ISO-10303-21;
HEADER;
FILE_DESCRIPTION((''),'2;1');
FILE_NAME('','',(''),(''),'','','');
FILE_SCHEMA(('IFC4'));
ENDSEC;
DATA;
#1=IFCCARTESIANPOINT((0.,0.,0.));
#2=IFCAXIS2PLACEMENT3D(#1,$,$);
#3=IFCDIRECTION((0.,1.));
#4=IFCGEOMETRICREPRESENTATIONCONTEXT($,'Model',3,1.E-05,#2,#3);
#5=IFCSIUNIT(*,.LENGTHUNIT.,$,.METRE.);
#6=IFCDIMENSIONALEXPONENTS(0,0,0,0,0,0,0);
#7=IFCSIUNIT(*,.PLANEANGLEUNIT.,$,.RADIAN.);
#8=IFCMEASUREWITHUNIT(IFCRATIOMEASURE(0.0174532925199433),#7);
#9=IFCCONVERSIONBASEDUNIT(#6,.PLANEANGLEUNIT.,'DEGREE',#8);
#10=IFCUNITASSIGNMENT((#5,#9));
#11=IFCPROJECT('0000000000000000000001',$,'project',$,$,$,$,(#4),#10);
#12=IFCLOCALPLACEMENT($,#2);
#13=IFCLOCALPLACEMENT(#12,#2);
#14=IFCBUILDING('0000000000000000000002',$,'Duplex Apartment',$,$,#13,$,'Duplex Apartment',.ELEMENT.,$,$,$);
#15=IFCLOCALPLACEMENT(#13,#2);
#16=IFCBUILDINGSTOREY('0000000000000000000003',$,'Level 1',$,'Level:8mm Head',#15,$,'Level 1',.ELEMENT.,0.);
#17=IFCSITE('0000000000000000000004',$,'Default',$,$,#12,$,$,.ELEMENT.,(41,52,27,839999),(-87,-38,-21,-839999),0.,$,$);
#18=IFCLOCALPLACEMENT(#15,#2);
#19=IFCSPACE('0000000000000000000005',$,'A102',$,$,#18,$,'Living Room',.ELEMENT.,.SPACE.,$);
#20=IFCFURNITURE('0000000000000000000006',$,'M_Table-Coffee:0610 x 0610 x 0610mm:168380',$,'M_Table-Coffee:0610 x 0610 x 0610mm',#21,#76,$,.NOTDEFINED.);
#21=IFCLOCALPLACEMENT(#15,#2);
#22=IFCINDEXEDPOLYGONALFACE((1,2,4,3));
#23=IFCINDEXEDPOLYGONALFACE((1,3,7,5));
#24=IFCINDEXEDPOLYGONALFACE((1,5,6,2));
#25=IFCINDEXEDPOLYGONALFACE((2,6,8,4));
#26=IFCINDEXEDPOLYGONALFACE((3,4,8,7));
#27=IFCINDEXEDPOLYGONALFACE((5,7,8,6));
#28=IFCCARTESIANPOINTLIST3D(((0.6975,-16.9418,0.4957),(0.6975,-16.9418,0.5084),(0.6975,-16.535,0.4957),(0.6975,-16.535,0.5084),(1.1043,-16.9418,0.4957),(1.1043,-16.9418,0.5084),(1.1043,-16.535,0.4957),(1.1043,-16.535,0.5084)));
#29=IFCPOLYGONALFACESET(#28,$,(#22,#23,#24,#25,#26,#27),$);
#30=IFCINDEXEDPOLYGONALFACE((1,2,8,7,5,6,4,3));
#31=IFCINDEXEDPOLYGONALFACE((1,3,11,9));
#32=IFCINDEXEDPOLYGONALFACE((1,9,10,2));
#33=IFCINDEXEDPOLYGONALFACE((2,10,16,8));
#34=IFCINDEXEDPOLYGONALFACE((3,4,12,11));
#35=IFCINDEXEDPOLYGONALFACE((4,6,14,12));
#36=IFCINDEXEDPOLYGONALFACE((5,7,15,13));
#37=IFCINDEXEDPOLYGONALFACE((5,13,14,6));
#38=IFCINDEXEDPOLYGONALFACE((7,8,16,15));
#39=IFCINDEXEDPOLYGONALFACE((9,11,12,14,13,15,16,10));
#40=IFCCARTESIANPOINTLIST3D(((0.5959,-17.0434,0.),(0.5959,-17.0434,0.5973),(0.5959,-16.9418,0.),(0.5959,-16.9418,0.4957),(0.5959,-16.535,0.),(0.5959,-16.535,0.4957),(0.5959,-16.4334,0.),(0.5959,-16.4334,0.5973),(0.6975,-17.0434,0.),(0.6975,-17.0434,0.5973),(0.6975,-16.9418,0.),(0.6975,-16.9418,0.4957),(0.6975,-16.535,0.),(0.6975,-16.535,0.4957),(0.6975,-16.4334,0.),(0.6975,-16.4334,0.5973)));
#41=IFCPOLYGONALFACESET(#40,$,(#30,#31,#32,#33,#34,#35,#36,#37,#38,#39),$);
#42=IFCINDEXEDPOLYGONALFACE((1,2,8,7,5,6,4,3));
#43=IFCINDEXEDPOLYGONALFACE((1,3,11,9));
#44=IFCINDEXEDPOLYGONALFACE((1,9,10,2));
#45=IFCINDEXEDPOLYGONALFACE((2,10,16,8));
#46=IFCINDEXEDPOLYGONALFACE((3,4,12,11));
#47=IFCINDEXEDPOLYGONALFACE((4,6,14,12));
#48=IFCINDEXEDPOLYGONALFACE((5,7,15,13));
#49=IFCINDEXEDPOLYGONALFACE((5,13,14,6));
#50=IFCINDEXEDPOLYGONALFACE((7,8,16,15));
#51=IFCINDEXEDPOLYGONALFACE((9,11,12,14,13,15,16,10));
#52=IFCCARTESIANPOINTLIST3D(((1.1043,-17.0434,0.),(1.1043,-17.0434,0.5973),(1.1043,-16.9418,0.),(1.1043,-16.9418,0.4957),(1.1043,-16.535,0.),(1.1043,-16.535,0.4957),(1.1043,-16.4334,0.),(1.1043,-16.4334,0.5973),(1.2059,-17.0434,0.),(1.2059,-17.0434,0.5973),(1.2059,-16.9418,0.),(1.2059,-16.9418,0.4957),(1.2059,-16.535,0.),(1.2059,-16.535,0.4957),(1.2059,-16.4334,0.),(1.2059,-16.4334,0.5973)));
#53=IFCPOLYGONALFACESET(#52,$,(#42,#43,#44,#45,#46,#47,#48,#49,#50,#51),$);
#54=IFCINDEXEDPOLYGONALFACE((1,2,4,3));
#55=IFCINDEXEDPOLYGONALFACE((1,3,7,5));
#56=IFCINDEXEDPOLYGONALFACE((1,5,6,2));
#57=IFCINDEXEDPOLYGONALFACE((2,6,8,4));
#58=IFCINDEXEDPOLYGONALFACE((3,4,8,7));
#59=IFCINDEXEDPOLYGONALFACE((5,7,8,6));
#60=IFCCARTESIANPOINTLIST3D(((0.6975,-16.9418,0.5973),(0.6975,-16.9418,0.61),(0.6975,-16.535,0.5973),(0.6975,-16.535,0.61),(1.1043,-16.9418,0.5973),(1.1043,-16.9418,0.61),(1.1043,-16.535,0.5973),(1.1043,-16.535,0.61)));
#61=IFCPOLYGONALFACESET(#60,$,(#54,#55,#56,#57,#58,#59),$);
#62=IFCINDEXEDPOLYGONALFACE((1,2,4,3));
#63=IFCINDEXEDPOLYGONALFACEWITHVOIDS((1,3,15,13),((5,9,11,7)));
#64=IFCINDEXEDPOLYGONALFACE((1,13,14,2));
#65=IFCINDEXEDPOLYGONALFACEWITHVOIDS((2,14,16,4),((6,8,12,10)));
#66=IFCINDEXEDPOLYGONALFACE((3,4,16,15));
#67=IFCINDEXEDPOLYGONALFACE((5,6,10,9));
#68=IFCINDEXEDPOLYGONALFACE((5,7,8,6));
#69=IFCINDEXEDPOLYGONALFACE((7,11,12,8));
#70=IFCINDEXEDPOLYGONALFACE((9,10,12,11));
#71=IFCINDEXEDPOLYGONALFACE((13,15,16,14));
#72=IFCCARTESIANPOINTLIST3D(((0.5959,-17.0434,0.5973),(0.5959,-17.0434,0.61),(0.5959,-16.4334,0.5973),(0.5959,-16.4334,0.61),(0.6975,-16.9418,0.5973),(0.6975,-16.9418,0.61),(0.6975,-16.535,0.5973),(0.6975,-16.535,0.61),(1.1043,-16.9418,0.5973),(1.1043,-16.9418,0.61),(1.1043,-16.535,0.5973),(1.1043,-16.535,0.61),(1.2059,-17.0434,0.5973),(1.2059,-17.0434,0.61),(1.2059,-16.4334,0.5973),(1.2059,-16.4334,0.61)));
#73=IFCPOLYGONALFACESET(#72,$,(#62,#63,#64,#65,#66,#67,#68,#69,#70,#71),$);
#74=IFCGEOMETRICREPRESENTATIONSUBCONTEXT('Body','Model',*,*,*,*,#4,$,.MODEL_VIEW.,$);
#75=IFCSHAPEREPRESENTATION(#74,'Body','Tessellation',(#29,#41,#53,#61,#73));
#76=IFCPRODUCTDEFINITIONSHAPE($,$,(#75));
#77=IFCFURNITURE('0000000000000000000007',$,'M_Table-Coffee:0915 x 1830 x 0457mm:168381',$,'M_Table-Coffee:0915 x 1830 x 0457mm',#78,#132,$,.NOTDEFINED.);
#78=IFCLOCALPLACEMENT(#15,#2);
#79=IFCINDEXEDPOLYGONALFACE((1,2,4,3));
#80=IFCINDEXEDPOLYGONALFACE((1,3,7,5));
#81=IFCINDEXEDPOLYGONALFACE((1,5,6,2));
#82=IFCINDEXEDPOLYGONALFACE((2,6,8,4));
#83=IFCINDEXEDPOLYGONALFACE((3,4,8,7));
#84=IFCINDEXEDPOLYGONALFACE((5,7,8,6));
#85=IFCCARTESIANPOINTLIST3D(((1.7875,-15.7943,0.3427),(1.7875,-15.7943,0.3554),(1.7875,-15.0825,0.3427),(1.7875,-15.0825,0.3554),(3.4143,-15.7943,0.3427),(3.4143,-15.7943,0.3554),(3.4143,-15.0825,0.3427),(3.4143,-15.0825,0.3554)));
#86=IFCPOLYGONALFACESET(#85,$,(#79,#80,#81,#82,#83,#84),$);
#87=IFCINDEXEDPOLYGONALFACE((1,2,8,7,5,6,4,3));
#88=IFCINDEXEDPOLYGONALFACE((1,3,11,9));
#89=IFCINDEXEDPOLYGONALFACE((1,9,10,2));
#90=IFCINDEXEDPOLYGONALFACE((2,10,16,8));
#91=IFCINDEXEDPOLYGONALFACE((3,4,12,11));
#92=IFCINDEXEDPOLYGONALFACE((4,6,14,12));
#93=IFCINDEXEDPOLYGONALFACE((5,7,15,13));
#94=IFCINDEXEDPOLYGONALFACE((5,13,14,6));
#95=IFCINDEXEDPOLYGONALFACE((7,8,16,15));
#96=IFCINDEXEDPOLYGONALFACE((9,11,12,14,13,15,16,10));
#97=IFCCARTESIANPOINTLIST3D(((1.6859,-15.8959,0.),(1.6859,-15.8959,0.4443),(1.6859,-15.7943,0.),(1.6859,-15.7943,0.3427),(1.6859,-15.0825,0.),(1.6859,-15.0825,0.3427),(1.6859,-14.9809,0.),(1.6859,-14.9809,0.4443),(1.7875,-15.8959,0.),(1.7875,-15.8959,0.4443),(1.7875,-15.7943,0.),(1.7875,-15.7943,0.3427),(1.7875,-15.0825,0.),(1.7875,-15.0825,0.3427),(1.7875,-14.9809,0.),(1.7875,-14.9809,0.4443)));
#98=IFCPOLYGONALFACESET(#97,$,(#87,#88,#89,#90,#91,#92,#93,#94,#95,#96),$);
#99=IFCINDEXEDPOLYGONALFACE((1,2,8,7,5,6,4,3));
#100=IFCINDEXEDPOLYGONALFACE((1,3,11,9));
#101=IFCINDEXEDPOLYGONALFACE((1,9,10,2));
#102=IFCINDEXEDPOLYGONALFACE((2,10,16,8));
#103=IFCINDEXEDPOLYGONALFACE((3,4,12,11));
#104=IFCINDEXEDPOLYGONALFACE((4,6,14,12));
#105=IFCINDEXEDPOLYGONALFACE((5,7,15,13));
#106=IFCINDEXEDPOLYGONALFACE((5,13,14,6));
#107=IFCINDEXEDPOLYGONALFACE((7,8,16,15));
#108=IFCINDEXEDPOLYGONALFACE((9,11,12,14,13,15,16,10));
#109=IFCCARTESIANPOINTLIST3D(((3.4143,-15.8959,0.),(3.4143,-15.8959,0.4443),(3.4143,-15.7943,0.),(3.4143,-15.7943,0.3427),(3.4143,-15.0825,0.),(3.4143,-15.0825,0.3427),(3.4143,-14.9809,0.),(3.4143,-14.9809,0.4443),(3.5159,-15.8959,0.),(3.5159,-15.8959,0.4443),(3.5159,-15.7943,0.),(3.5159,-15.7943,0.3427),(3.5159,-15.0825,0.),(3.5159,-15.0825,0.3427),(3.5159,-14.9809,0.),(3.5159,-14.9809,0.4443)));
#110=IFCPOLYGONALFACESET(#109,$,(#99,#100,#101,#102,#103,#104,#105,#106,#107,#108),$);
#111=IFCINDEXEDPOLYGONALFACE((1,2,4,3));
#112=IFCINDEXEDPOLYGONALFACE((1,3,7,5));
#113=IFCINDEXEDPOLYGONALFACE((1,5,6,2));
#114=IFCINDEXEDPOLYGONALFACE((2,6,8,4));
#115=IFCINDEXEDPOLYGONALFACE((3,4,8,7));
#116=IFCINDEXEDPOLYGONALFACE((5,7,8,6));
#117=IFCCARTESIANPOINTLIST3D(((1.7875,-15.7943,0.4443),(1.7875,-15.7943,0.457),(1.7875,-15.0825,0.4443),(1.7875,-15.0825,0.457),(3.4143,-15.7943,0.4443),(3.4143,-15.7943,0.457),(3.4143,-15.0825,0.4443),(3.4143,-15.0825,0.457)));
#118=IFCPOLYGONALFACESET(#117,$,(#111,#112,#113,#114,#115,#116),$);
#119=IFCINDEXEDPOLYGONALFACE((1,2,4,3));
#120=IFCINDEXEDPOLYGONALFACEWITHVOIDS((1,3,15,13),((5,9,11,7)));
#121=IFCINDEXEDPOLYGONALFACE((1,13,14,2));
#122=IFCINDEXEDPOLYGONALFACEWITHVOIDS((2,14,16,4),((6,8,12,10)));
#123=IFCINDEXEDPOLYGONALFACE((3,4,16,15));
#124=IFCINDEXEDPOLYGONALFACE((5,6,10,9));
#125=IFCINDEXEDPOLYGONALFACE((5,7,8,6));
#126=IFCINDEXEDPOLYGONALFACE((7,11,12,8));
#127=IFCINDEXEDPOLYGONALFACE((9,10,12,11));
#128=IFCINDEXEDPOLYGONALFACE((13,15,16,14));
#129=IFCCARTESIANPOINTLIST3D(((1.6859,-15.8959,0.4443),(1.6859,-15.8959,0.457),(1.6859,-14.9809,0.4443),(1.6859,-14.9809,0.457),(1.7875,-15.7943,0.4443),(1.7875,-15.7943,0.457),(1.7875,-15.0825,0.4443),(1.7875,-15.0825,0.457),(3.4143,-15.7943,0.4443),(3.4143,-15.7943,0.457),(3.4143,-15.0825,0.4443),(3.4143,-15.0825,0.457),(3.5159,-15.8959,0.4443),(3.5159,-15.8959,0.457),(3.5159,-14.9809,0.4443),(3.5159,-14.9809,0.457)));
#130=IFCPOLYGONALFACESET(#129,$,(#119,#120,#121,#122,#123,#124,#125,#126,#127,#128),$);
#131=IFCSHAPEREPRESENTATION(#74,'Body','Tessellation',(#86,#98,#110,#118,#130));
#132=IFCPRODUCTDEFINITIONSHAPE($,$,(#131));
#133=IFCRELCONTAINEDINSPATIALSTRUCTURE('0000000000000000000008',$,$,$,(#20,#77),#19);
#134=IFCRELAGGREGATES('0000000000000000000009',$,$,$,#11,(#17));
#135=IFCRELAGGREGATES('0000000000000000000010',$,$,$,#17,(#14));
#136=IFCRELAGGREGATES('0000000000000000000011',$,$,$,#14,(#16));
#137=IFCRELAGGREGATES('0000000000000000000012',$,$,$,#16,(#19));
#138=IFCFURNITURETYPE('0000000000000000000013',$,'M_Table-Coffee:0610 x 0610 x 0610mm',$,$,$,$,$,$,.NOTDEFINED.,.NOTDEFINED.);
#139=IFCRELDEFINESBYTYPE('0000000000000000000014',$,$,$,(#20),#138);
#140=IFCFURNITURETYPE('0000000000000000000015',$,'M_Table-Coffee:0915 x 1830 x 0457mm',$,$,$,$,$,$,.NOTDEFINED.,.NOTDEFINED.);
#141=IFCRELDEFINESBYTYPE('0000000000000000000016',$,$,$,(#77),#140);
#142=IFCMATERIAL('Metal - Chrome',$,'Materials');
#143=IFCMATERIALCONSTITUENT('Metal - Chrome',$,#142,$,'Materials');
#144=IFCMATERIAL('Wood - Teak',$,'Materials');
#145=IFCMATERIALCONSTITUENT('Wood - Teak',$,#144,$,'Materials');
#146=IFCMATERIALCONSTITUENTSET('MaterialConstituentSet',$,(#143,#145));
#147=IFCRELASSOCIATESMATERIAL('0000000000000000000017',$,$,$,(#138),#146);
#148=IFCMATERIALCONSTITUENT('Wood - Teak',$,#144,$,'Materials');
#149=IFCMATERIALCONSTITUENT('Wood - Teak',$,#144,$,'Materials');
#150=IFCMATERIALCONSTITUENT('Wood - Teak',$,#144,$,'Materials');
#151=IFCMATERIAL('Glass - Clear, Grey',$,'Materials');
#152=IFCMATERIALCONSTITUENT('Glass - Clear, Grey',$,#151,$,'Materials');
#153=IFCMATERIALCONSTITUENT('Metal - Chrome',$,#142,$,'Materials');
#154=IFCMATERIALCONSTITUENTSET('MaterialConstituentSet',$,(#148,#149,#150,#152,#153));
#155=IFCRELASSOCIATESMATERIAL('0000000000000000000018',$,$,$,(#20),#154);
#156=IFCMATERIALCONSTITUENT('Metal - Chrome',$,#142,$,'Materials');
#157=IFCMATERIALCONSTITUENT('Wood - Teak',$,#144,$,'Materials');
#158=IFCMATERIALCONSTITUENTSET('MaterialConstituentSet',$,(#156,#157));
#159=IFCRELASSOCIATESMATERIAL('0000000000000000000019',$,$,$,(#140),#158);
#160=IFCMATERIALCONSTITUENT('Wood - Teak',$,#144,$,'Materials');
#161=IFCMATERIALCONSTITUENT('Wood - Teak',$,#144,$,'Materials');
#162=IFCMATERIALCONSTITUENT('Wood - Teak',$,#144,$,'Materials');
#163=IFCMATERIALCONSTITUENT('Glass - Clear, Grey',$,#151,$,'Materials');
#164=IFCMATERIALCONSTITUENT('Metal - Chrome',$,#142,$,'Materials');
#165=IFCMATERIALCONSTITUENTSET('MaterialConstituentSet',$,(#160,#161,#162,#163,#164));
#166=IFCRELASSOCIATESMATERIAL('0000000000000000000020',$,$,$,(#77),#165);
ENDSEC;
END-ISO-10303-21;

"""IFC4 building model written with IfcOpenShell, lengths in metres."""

from ifc_helpers import new_model, entity, si_unit, converted_unit, direction, frame, origin, place, context, subcontext, project, spatial, indexed_curve, outline, extrude, source, transform, mapped, material, constituent, constituent_set, type_object, type_shapes, element, save


model = new_model("IFC4")

# Units and contexts
model_context = context("Model", 3, precision=1e-05, world=origin(), true_north=direction((0.0, 1.0)))
body_context = subcontext(model_context, "Body", "Model", "MODEL_VIEW")
ifc_project = project(units=[si_unit("LENGTHUNIT", "METRE"), converted_unit("PLANEANGLEUNIT", "DEGREE", entity("IfcRatioMeasure", 0.0174532925199433), si_unit("PLANEANGLEUNIT", "RADIAN"), dimensions=[0, 0, 0, 0, 0, 0, 0])], contexts=[model_context])

# Site, building, storey
site_placement = place(None, origin())
site = spatial("IfcSite", under=ifc_project, at=site_placement, Name="Default", CompositionType="ELEMENT", RefLatitude=(41, 52, 27, 839999), RefLongitude=(-87, -38, -21, -839999), RefElevation=0.0)
building_placement = place(site_placement, origin())
building = spatial("IfcBuilding", under=site, at=building_placement, Name="Duplex Apartment", LongName="Duplex Apartment", CompositionType="ELEMENT")
storey_placement = place(building_placement, origin())
storey = spatial("IfcBuildingStorey", under=building, at=storey_placement, Name="Level 1", ObjectType="Level:8mm Head", LongName="Level 1", CompositionType="ELEMENT", Elevation=0.0)

# Shared definitions
space_1_placement = place(storey_placement, origin())
space_1 = spatial("IfcSpace", under=storey, at=space_1_placement, Name="A102", LongName="Living Room", CompositionType="ELEMENT", PredefinedType="SPACE")

# Furniture
ifc_material_1 = material(Name="Wood - Teak", Category="Materials")
ifc_material_2 = material(Name="Glass - Clear, Grey", Category="Materials")
ifc_material_3 = material(Name="Metal - Chrome", Category="Materials")
ifc_constituent_1 = constituent(ifc_material_3, Name="Metal - Chrome", Category="Materials")
ifc_constituent_2 = constituent(ifc_material_1, Name="Wood - Teak", Category="Materials")
ifc_constituent_set_1 = constituent_set(constituents=[ifc_constituent_1, ifc_constituent_2], Name="MaterialConstituentSet")
furniture_type_1 = type_object("IfcFurnitureType", Name="M_Table-Coffee:0610 x 0610 x 0610mm", AssemblyPlace="NOTDEFINED", PredefinedType="NOTDEFINED", material=ifc_constituent_set_1)
shared_shape_1 = source(origin(), body_context, "Body", "SweptSolid", [
    extrude(outline(indexed_curve([(-0.2034, -0.2034), (0.2034, -0.2034), (0.2034, 0.2034), (-0.2034, 0.2034), (-0.2034, -0.2034)], self_intersect=False)), frame((0.0183, 0.0952, 0.4957), z_axis=(0.0, 0.0, 1.0), x_axis=(-1.0, 0.0, 0.0)), (0.0, 0.0, 1.0), 0.0127),
    extrude(outline(indexed_curve([(-0.2732, -0.305), (0.324, -0.305), (0.324, 0.305), (-0.2732, 0.305), (-0.2732, 0.2034), (0.2225, 0.2034), (0.2225, -0.2034), (-0.2732, -0.2034), (-0.2732, -0.305)], self_intersect=False)), frame((0.2217, 0.0952, 0.2732), z_axis=(1.0, 0.0, 0.0), x_axis=(0.0, 0.0, 1.0)), (0.0, 0.0, 1.0), 0.1016),
    extrude(outline(indexed_curve([(-0.305, -0.3241), (0.305, -0.3241), (0.305, 0.2733), (0.2034, 0.2733), (0.2034, -0.2224), (-0.2034, -0.2224), (-0.2034, 0.2733), (-0.305, 0.2733), (-0.305, -0.3241)], self_intersect=False)), frame((-0.2867, 0.0952, 0.2733), z_axis=(1.0, 0.0, 0.0), x_axis=(0.0, -1.0, 0.0)), (0.0, 0.0, 1.0), 0.1016),
    extrude(outline(indexed_curve([(-0.2034, -0.2034), (0.2034, -0.2034), (0.2034, 0.2034), (-0.2034, 0.2034), (-0.2034, -0.2034)], self_intersect=False)), frame((0.0183, 0.0952, 0.5973), z_axis=(0.0, 0.0, 1.0), x_axis=(-1.0, 0.0, 0.0)), (0.0, 0.0, 1.0), 0.0127),
    extrude(outline(indexed_curve([(-0.305, -0.305), (0.305, -0.305), (0.305, 0.305), (-0.305, 0.305), (-0.305, -0.305)], self_intersect=False), holes=[indexed_curve([(-0.2034, -0.2034), (-0.2034, 0.2034), (0.2034, 0.2034), (0.2034, -0.2034), (-0.2034, -0.2034)], self_intersect=False)]), frame((0.0183, 0.0952, 0.5973), z_axis=(0.0, 0.0, 1.0), x_axis=(-1.0, 0.0, 0.0)), (0.0, 0.0, 1.0), 0.0127),
])
type_shapes(furniture_type_1, [shared_shape_1])
ifc_constituent_3 = constituent(ifc_material_1, Name="Wood - Teak", Category="Materials")
ifc_constituent_4 = constituent(ifc_material_1, Name="Wood - Teak", Category="Materials")
ifc_constituent_5 = constituent(ifc_material_1, Name="Wood - Teak", Category="Materials")
ifc_constituent_6 = constituent(ifc_material_2, Name="Glass - Clear, Grey", Category="Materials")
ifc_constituent_7 = constituent(ifc_material_3, Name="Metal - Chrome", Category="Materials")
ifc_constituent_set_2 = constituent_set(constituents=[ifc_constituent_3, ifc_constituent_4, ifc_constituent_5, ifc_constituent_6, ifc_constituent_7], Name="MaterialConstituentSet")
furniture_1_placement = place(space_1_placement, frame((0.9192, -16.6432, 0.0), z_axis=(0.0, 0.0, 1.0), x_axis=(-1.0, 0.0, 0.0)))
element("IfcFurniture", 1, at=furniture_1_placement, inside=space_1, type_object=furniture_type_1, material=ifc_constituent_set_2, Name="M_Table-Coffee:0610 x 0610 x 0610mm:168380", ObjectType="M_Table-Coffee:0610 x 0610 x 0610mm", PredefinedType="NOTDEFINED", context=body_context, shape_type="MappedRepresentation", body=[
    mapped(shared_shape_1, transform((0.0, 0.0, 0.0), scale=1.0)),
])
ifc_constituent_8 = constituent(ifc_material_1, Name="Wood - Teak", Category="Materials")
ifc_constituent_9 = constituent(ifc_material_1, Name="Wood - Teak", Category="Materials")
ifc_constituent_10 = constituent(ifc_material_1, Name="Wood - Teak", Category="Materials")
ifc_constituent_11 = constituent(ifc_material_2, Name="Glass - Clear, Grey", Category="Materials")
ifc_constituent_12 = constituent(ifc_material_3, Name="Metal - Chrome", Category="Materials")
ifc_constituent_set_3 = constituent_set(constituents=[ifc_constituent_8, ifc_constituent_9, ifc_constituent_10, ifc_constituent_11, ifc_constituent_12], Name="MaterialConstituentSet")
ifc_constituent_13 = constituent(ifc_material_3, Name="Metal - Chrome", Category="Materials")
ifc_constituent_14 = constituent(ifc_material_1, Name="Wood - Teak", Category="Materials")
ifc_constituent_set_4 = constituent_set(constituents=[ifc_constituent_13, ifc_constituent_14], Name="MaterialConstituentSet")
furniture_type_2 = type_object("IfcFurnitureType", Name="M_Table-Coffee:0915 x 1830 x 0457mm", AssemblyPlace="NOTDEFINED", PredefinedType="NOTDEFINED", material=ifc_constituent_set_4)
shared_shape_2 = source(origin(), body_context, "Body", "SweptSolid", [
    extrude(outline(indexed_curve([(-0.8134, -0.3559), (0.8134, -0.3559), (0.8134, 0.3559), (-0.8134, 0.3559), (-0.8134, -0.3559)], self_intersect=False)), frame((0.0183, 0.0952, 0.3427), z_axis=(0.0, 0.0, 1.0), x_axis=(-1.0, 0.0, 0.0)), (0.0, 0.0, 1.0), 0.0127),
    extrude(outline(indexed_curve([(-0.1967, -0.4575), (0.2475, -0.4575), (0.2475, 0.4575), (-0.1967, 0.4575), (-0.1967, 0.3559), (0.146, 0.3559), (0.146, -0.3559), (-0.1967, -0.3559), (-0.1967, -0.4575)], self_intersect=False)), frame((0.8317, 0.0952, 0.1967), z_axis=(1.0, 0.0, 0.0), x_axis=(0.0, 0.0, 1.0)), (0.0, 0.0, 1.0), 0.1016),
    extrude(outline(indexed_curve([(-0.4575, -0.2476), (0.4575, -0.2476), (0.4575, 0.1968), (0.3559, 0.1968), (0.3559, -0.1459), (-0.3559, -0.1459), (-0.3559, 0.1968), (-0.4575, 0.1968), (-0.4575, -0.2476)], self_intersect=False)), frame((-0.8967, 0.0952, 0.1968), z_axis=(1.0, 0.0, 0.0), x_axis=(0.0, -1.0, 0.0)), (0.0, 0.0, 1.0), 0.1016),
    extrude(outline(indexed_curve([(-0.8134, -0.3559), (0.8134, -0.3559), (0.8134, 0.3559), (-0.8134, 0.3559), (-0.8134, -0.3559)], self_intersect=False)), frame((0.0183, 0.0952, 0.4443), z_axis=(0.0, 0.0, 1.0), x_axis=(-1.0, 0.0, 0.0)), (0.0, 0.0, 1.0), 0.0127),
    extrude(outline(indexed_curve([(-0.915, -0.4575), (0.915, -0.4575), (0.915, 0.4575), (-0.915, 0.4575), (-0.915, -0.4575)], self_intersect=False), holes=[indexed_curve([(-0.8134, -0.3559), (-0.8134, 0.3559), (0.8134, 0.3559), (0.8134, -0.3559), (-0.8134, -0.3559)], self_intersect=False)]), frame((0.0183, 0.0952, 0.4443), z_axis=(0.0, 0.0, 1.0), x_axis=(-1.0, 0.0, 0.0)), (0.0, 0.0, 1.0), 0.0127),
])
type_shapes(furniture_type_2, [shared_shape_2])
furniture_2_placement = place(space_1_placement, frame((2.6192, -15.3432, 0.0), z_axis=(0.0, 0.0, 1.0), x_axis=(-1.0, 0.0, 0.0)))
element("IfcFurniture", 2, at=furniture_2_placement, inside=space_1, type_object=furniture_type_2, material=ifc_constituent_set_3, Name="M_Table-Coffee:0915 x 1830 x 0457mm:168381", ObjectType="M_Table-Coffee:0915 x 1830 x 0457mm", PredefinedType="NOTDEFINED", context=body_context, shape_type="MappedRepresentation", body=[
    mapped(shared_shape_2, transform((0.0, 0.0, 0.0), scale=1.0)),
])

save(model, "model.ifc")
